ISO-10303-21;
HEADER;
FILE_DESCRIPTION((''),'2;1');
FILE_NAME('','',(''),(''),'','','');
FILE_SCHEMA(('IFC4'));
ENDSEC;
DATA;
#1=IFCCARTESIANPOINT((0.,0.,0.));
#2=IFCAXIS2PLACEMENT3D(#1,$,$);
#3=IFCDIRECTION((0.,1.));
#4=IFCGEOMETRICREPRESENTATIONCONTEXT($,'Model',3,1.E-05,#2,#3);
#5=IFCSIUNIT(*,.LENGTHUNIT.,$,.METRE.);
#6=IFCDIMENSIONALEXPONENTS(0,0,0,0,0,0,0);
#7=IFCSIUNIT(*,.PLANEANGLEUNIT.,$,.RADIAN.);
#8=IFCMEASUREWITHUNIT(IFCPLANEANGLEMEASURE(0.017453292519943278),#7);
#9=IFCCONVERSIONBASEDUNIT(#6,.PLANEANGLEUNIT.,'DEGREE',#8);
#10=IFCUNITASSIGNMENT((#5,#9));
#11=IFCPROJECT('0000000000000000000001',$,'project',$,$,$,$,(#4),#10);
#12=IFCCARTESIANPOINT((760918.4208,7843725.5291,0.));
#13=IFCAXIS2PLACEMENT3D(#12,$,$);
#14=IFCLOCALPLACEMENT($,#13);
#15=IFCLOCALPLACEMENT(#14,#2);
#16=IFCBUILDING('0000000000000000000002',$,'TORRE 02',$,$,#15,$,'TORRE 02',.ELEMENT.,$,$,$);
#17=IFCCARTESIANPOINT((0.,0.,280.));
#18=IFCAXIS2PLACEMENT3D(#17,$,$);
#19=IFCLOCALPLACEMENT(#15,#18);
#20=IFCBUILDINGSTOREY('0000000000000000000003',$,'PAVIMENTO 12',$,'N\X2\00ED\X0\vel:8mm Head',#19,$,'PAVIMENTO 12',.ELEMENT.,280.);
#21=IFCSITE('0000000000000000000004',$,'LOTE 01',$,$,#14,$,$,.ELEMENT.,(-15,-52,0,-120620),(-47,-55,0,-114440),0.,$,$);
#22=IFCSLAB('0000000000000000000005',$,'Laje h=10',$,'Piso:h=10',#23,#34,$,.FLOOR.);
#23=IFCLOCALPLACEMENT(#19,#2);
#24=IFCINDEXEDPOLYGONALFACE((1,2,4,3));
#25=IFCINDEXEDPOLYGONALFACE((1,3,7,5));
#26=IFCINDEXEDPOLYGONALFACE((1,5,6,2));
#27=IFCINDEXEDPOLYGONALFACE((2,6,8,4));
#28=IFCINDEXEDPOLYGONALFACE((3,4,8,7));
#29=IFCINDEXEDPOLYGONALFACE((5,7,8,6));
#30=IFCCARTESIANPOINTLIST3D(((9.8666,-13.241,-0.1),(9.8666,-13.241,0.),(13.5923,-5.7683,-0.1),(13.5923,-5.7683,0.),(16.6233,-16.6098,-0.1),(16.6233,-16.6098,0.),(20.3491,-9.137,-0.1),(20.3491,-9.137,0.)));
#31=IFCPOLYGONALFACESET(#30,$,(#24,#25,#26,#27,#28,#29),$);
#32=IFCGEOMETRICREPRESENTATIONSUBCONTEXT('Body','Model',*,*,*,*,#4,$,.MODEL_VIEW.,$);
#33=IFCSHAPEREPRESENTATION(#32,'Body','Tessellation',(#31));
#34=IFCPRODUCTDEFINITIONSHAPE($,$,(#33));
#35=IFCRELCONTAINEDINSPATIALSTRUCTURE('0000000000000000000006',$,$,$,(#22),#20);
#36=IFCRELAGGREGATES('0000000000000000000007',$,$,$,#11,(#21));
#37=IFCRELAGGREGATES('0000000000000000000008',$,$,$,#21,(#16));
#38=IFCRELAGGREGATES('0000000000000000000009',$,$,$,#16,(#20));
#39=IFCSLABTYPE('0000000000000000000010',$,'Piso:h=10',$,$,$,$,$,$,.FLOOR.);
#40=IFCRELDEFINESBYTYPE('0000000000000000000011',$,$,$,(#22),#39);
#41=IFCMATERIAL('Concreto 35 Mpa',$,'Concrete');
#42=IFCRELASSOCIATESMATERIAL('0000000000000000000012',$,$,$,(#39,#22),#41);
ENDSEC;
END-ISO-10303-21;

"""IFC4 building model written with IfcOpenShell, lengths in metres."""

from ifc_helpers import new_model, entity, si_unit, converted_unit, direction, frame, origin, place, context, subcontext, project, spatial, indexed_curve, outline, extrude, material, type_object, element, save


model = new_model("IFC4")

# Units and contexts
model_context = context("Model", 3, precision=1e-05, world=origin(), true_north=direction((0.0, 1.0)))
body_context = subcontext(model_context, "Body", "Model", "MODEL_VIEW")
ifc_project = project(units=[si_unit("LENGTHUNIT", "METRE"), converted_unit("PLANEANGLEUNIT", "DEGREE", entity("IfcPlaneAngleMeasure", 0.017453292519943278), si_unit("PLANEANGLEUNIT", "RADIAN"), dimensions=[0, 0, 0, 0, 0, 0, 0])], contexts=[model_context])

# Site, building, storey
site_placement = place(None, frame((760918.4208, 7843725.5291, 0.0)))
site = spatial("IfcSite", under=ifc_project, at=site_placement, Name="LOTE 01", CompositionType="ELEMENT", RefLatitude=(-15, -52, 0, -120620), RefLongitude=(-47, -55, 0, -114440), RefElevation=0.0)
building_placement = place(site_placement, origin())
building = spatial("IfcBuilding", under=site, at=building_placement, Name="TORRE 02", LongName="TORRE 02", CompositionType="ELEMENT")
storey_placement = place(building_placement, frame((0.0, 0.0, 280.0)))
storey = spatial("IfcBuildingStorey", under=building, at=storey_placement, Name="PAVIMENTO 12", ObjectType="Nível:8mm Head", LongName="PAVIMENTO 12", CompositionType="ELEMENT", Elevation=280.0)

# Slab
ifc_material_1 = material(Name="Concreto 35 Mpa", Category="Concrete")
slab_type = type_object("IfcSlabType", Name="Piso:h=10", PredefinedType="FLOOR", material=ifc_material_1)
slab_1_placement = place(storey_placement, origin())
element("IfcSlab", 1, at=slab_1_placement, inside=storey, type_object=slab_type, material=ifc_material_1, Name="Laje h=10", ObjectType="Piso:h=10", PredefinedType="FLOOR", context=body_context, shape_type="SweptSolid", body=[
    extrude(outline(indexed_curve([(-4.175, -3.775), (4.175, -3.775), (4.175, 3.775), (-4.175, 3.775), (-4.175, -3.775)], self_intersect=False)), frame((15.1078, -11.189, 0.0), z_axis=(0.0, 0.0, -1.0), x_axis=(-0.446198, -0.894934, 0.0)), (0.0, 0.0, 1.0), 0.1),
])

save(model, "model.ifc")
